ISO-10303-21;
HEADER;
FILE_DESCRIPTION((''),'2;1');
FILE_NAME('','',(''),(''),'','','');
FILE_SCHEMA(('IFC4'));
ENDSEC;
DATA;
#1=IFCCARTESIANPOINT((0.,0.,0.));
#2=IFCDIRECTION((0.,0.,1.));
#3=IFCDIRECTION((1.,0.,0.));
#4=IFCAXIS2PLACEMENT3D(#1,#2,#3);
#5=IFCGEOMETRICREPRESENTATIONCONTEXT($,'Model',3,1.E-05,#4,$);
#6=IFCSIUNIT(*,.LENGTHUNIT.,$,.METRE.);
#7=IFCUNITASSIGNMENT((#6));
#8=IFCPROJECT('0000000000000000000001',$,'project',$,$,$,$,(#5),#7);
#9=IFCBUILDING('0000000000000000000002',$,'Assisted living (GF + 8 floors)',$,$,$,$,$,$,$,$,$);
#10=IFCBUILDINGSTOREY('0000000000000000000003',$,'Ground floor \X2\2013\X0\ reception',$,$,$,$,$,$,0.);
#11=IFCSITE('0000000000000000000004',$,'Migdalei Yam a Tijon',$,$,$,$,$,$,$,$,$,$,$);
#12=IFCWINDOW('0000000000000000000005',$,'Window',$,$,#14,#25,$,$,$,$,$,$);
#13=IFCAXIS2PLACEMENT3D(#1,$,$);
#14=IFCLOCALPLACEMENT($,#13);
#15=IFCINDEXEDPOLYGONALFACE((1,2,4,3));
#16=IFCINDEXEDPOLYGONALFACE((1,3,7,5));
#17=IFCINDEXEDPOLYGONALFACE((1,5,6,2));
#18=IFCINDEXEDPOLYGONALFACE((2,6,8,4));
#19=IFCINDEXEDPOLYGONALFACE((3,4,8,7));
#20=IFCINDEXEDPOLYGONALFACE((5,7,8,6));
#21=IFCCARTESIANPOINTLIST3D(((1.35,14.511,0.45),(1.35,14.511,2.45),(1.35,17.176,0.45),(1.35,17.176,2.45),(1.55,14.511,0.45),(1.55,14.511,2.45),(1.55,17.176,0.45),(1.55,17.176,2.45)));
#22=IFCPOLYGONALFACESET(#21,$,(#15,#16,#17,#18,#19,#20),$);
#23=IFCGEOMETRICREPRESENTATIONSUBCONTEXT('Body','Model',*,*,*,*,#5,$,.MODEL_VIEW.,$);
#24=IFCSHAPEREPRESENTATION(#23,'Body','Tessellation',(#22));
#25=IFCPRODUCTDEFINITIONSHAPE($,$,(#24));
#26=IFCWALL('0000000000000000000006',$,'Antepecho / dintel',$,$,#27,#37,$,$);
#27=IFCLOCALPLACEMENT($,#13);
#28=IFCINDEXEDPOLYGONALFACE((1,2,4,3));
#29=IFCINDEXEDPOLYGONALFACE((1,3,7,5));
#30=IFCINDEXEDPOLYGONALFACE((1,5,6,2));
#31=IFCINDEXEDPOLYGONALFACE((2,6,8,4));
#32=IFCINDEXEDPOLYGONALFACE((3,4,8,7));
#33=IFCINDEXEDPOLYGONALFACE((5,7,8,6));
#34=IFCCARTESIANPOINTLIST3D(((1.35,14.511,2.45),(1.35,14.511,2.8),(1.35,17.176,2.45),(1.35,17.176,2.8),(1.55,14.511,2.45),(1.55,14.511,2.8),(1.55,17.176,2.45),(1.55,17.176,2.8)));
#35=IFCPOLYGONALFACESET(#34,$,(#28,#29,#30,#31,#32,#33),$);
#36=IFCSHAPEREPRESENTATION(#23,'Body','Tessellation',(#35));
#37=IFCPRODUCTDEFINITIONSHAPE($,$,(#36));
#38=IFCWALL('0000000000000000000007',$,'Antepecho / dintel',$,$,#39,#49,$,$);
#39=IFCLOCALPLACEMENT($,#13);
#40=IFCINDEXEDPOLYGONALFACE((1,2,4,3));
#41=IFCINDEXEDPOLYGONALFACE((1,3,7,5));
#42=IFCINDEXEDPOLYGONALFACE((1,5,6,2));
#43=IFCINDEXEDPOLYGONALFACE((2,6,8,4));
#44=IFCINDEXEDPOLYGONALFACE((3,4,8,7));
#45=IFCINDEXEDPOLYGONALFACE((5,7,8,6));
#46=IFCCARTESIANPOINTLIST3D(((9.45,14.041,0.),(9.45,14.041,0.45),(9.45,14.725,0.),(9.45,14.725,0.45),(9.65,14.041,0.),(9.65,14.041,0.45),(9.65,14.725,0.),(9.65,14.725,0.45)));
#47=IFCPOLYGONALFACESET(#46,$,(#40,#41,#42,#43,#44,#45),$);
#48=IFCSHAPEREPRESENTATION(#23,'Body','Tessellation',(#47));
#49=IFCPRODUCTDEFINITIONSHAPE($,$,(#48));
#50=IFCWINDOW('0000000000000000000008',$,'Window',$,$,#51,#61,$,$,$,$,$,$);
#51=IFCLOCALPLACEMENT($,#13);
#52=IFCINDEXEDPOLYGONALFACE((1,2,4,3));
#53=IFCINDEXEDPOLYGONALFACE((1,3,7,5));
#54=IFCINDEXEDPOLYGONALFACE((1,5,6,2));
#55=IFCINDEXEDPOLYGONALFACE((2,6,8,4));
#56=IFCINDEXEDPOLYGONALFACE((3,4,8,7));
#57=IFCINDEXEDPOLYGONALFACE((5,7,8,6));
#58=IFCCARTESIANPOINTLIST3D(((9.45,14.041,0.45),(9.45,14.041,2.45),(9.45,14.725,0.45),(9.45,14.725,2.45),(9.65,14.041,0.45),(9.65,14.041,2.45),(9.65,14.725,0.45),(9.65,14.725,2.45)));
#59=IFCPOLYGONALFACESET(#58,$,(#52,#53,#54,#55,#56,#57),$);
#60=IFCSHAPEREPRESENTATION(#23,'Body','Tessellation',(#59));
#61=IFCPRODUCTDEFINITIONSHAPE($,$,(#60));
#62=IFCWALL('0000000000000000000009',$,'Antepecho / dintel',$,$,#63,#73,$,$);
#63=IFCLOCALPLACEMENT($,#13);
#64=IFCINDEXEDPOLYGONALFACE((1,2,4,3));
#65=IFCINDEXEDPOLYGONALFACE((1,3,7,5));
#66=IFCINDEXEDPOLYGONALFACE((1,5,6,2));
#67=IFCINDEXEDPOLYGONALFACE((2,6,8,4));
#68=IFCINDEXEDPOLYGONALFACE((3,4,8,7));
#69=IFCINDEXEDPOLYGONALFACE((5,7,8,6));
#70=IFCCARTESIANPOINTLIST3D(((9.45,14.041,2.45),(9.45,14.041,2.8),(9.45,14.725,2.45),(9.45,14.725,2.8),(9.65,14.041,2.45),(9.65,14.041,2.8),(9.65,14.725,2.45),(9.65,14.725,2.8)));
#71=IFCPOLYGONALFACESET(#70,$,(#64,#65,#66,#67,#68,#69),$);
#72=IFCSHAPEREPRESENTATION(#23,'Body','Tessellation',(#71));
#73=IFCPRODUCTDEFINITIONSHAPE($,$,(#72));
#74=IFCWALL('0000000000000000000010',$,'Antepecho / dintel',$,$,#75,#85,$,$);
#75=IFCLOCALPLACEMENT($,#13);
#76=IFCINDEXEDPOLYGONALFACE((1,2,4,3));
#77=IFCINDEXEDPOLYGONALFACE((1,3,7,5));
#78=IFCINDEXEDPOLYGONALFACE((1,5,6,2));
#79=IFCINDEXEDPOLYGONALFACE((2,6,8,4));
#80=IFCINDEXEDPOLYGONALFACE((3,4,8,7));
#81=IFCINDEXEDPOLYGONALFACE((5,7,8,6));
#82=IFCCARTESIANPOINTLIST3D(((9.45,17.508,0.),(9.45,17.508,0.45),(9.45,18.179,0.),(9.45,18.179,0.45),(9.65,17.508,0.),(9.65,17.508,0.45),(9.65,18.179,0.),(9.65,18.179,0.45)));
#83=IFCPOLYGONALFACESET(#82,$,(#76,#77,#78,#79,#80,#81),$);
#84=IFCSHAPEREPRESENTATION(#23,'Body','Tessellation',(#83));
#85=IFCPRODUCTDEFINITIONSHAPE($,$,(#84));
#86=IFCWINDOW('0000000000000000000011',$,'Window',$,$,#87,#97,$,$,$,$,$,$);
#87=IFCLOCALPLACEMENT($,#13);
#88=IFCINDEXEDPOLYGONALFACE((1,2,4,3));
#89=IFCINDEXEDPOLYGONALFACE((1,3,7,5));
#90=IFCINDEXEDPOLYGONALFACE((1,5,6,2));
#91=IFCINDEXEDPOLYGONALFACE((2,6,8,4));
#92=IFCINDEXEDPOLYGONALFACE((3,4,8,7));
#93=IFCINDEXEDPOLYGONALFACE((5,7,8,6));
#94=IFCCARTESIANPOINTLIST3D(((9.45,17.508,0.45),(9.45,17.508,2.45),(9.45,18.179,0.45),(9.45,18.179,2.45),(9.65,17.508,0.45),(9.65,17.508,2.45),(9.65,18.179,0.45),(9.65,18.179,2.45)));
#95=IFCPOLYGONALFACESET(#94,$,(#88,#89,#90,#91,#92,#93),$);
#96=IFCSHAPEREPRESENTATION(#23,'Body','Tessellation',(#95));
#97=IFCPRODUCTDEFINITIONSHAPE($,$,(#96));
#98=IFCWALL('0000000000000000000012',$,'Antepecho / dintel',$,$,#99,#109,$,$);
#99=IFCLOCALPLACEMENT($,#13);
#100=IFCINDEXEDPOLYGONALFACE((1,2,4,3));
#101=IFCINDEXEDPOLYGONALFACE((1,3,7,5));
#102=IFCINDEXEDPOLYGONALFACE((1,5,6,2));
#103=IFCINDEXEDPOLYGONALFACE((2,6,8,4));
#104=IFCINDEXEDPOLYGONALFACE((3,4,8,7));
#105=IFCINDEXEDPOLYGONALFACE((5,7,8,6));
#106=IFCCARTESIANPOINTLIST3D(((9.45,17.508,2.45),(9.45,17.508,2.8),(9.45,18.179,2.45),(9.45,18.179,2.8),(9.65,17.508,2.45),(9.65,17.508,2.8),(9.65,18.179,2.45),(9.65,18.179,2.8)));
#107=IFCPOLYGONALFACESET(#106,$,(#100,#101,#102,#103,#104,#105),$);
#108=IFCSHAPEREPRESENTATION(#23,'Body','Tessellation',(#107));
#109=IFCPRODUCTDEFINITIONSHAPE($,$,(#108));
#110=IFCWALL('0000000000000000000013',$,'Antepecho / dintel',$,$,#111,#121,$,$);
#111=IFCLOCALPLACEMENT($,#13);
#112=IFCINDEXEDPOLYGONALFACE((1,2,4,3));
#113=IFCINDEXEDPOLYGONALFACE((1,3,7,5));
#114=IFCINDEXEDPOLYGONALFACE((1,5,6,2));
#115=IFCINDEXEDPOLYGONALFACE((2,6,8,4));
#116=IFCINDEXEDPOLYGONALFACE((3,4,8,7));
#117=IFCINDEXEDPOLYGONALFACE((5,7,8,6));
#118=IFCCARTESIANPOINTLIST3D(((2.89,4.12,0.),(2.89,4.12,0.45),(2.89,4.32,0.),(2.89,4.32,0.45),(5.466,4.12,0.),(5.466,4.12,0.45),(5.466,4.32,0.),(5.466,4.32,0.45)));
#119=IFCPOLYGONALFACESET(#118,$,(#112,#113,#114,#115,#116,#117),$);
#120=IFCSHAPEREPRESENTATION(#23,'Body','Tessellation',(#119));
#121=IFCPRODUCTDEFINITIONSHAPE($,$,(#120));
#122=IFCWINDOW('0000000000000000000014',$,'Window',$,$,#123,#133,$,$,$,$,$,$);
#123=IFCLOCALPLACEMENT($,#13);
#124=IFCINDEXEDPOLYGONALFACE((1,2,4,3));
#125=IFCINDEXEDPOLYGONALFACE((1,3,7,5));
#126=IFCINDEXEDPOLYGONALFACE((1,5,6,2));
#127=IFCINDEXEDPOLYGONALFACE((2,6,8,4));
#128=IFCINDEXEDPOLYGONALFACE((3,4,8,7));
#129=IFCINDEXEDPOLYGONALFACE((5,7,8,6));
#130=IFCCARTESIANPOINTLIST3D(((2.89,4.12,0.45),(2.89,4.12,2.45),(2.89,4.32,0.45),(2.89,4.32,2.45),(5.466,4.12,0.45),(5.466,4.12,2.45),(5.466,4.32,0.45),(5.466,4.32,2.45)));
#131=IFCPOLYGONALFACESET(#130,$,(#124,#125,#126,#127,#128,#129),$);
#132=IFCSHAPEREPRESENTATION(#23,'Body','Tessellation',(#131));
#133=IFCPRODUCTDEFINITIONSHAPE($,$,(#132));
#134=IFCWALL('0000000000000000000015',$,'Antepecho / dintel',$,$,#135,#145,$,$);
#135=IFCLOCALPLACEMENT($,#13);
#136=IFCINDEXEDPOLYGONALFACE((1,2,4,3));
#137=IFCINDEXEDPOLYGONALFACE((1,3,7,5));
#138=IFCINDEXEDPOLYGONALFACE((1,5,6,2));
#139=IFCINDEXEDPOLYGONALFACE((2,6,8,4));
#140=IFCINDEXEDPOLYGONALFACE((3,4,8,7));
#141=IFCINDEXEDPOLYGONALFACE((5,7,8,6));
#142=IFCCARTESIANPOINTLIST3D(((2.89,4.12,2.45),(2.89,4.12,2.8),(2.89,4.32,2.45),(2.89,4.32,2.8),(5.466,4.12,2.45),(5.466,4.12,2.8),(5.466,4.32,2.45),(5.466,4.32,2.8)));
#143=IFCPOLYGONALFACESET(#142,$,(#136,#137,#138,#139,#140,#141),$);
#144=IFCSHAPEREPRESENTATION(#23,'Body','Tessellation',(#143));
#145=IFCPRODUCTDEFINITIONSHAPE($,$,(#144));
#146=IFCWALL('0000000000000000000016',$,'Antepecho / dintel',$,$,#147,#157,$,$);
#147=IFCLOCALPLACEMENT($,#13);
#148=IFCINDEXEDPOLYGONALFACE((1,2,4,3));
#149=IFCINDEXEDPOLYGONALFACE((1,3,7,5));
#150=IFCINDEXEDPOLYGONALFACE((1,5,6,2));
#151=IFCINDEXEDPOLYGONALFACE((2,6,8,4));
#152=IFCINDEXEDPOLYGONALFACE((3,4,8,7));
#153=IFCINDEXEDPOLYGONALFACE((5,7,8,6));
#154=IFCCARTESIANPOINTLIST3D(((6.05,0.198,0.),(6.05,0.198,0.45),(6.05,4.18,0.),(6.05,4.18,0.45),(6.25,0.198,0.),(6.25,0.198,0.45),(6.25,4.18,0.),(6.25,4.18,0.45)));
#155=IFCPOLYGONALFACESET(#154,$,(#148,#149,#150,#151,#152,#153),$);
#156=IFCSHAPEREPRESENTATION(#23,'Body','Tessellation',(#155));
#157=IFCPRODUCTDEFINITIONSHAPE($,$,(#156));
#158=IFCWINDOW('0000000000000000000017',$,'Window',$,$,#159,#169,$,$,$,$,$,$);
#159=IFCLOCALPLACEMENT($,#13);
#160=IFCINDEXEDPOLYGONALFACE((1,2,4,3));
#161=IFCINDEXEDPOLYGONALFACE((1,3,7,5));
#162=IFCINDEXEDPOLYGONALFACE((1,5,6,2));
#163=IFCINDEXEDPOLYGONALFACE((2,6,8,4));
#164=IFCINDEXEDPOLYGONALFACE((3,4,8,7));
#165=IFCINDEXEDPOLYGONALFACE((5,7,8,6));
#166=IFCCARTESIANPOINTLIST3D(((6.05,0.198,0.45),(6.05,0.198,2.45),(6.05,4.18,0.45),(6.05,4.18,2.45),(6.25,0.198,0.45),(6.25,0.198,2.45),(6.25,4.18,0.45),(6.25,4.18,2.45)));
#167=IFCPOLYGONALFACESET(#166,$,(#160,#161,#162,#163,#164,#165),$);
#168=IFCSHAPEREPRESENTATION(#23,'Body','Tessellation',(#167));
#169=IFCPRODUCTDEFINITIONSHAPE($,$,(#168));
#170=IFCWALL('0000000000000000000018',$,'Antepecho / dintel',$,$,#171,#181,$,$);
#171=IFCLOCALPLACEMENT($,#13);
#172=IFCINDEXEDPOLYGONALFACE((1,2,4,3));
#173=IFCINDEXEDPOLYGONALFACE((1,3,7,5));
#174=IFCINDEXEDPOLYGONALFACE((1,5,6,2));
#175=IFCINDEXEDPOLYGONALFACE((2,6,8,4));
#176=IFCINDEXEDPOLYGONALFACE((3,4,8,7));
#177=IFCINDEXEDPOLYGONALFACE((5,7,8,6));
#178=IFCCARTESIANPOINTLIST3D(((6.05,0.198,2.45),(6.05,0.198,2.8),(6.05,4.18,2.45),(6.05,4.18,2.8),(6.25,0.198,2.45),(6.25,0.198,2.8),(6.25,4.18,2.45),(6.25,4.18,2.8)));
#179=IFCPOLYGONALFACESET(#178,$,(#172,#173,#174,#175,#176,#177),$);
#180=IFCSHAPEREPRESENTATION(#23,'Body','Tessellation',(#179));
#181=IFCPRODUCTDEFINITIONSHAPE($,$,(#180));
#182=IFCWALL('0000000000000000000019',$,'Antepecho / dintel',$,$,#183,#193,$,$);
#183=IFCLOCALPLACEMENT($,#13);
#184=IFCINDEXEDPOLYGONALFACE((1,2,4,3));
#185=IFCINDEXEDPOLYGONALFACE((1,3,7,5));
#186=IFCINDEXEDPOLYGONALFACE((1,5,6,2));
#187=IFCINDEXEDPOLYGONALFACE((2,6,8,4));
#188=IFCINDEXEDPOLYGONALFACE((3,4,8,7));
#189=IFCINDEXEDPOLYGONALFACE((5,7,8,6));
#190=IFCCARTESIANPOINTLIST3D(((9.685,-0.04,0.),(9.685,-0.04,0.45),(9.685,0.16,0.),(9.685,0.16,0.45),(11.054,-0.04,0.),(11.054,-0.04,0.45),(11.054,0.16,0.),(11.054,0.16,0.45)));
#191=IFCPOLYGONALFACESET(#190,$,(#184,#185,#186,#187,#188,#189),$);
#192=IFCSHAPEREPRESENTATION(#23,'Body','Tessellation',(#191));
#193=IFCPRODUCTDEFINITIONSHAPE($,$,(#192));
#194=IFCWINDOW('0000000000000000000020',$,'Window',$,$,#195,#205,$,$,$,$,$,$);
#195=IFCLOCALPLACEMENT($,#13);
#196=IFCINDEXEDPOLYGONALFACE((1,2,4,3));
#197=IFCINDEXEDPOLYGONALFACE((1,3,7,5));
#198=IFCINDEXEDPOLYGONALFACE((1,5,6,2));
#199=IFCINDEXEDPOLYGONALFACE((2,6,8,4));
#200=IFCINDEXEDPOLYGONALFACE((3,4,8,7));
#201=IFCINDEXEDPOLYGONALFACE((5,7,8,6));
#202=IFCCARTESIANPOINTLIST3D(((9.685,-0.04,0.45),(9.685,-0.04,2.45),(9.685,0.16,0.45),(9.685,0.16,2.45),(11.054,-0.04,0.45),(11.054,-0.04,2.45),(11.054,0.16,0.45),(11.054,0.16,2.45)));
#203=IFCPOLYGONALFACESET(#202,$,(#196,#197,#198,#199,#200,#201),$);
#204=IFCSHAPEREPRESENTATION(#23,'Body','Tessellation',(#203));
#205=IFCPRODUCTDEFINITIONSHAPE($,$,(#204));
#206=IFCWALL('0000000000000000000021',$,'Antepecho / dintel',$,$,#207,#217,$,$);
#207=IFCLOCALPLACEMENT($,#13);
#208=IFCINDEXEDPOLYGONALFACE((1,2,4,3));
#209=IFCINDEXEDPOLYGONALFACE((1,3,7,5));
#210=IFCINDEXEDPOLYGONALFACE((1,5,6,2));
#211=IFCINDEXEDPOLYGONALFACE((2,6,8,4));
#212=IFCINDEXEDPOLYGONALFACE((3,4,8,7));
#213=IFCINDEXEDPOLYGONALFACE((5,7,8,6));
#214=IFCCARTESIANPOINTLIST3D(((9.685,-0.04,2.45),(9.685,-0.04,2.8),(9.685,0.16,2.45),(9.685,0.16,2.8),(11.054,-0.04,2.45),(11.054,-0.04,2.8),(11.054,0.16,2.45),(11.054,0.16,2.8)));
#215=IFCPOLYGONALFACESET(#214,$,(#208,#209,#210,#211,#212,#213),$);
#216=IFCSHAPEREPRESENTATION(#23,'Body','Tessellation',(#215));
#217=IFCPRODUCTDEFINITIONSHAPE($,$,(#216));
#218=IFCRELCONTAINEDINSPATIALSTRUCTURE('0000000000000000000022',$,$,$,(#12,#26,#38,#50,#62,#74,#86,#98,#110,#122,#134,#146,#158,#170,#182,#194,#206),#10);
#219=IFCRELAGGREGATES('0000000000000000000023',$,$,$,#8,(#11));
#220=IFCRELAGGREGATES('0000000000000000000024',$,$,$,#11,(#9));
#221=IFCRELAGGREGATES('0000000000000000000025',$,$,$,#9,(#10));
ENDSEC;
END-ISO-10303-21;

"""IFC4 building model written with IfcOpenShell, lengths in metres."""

from ifc_helpers import new_model, si_unit, frame, origin_with_axes, context, subcontext, project, spatial, line, indexed_curve, outline, extrude, element, save


model = new_model("IFC4")

# Units and contexts
model_context = context("Model", 3, precision=1e-05, world=origin_with_axes())
body_context = subcontext(model_context, "Body", "Model", "MODEL_VIEW")
ifc_project = project(units=[si_unit("LENGTHUNIT", "METRE")], contexts=[model_context])

# Site, building, storey
site = spatial("IfcSite", under=ifc_project, Name="Migdalei Yam a Tijon")
building = spatial("IfcBuilding", under=site, Name="Assisted living (GF + 8 floors)")
storey = spatial("IfcBuildingStorey", under=building, Name="Ground floor – reception", Elevation=0.0)

# Window
element("IfcWindow", 1, inside=storey, Name="Window", context=body_context, shape_type="SweptSolid", body=[
    extrude(outline(indexed_curve([(0.0, 0.0), (0.2, 0.0), (0.2, 2.665), (0.0, 2.665)], segments=[line(1, 2, 3, 4, 1)])), frame((1.35, 14.511, 0.45), z_axis=(0.0, 0.0, 1.0), x_axis=(1.0, 0.0, 0.0)), (0.0, 0.0, 1.0), 2.0),
])

# Walls
element("IfcWall", 2, inside=storey, Name="Antepecho / dintel", context=body_context, shape_type="SweptSolid", body=[
    extrude(outline(indexed_curve([(0.0, 0.0), (0.2, 0.0), (0.2, 2.665), (0.0, 2.665)], segments=[line(1, 2, 3, 4, 1)])), frame((1.35, 14.511, 2.45), z_axis=(0.0, 0.0, 1.0), x_axis=(1.0, 0.0, 0.0)), (0.0, 0.0, 1.0), 0.35),
])
element("IfcWall", 3, inside=storey, Name="Antepecho / dintel", context=body_context, shape_type="SweptSolid", body=[
    extrude(outline(indexed_curve([(0.0, 0.0), (0.2, 0.0), (0.2, 0.684), (0.0, 0.684)], segments=[line(1, 2, 3, 4, 1)])), frame((9.45, 14.041, 0.0), z_axis=(0.0, 0.0, 1.0), x_axis=(1.0, 0.0, 0.0)), (0.0, 0.0, 1.0), 0.45),
])

# Window
element("IfcWindow", 4, inside=storey, Name="Window", context=body_context, shape_type="SweptSolid", body=[
    extrude(outline(indexed_curve([(0.0, 0.0), (0.2, 0.0), (0.2, 0.684), (0.0, 0.684)], segments=[line(1, 2, 3, 4, 1)])), frame((9.45, 14.041, 0.45), z_axis=(0.0, 0.0, 1.0), x_axis=(1.0, 0.0, 0.0)), (0.0, 0.0, 1.0), 2.0),
])

# Walls
element("IfcWall", 5, inside=storey, Name="Antepecho / dintel", context=body_context, shape_type="SweptSolid", body=[
    extrude(outline(indexed_curve([(0.0, 0.0), (0.2, 0.0), (0.2, 0.684), (0.0, 0.684)], segments=[line(1, 2, 3, 4, 1)])), frame((9.45, 14.041, 2.45), z_axis=(0.0, 0.0, 1.0), x_axis=(1.0, 0.0, 0.0)), (0.0, 0.0, 1.0), 0.35),
])
element("IfcWall", 6, inside=storey, Name="Antepecho / dintel", context=body_context, shape_type="SweptSolid", body=[
    extrude(outline(indexed_curve([(0.0, 0.0), (0.2, 0.0), (0.2, 0.671), (0.0, 0.671)], segments=[line(1, 2, 3, 4, 1)])), frame((9.45, 17.508, 0.0), z_axis=(0.0, 0.0, 1.0), x_axis=(1.0, 0.0, 0.0)), (0.0, 0.0, 1.0), 0.45),
])

# Window
element("IfcWindow", 7, inside=storey, Name="Window", context=body_context, shape_type="SweptSolid", body=[
    extrude(outline(indexed_curve([(0.0, 0.0), (0.2, 0.0), (0.2, 0.671), (0.0, 0.671)], segments=[line(1, 2, 3, 4, 1)])), frame((9.45, 17.508, 0.45), z_axis=(0.0, 0.0, 1.0), x_axis=(1.0, 0.0, 0.0)), (0.0, 0.0, 1.0), 2.0),
])

# Walls
element("IfcWall", 8, inside=storey, Name="Antepecho / dintel", context=body_context, shape_type="SweptSolid", body=[
    extrude(outline(indexed_curve([(0.0, 0.0), (0.2, 0.0), (0.2, 0.671), (0.0, 0.671)], segments=[line(1, 2, 3, 4, 1)])), frame((9.45, 17.508, 2.45), z_axis=(0.0, 0.0, 1.0), x_axis=(1.0, 0.0, 0.0)), (0.0, 0.0, 1.0), 0.35),
])
element("IfcWall", 9, inside=storey, Name="Antepecho / dintel", context=body_context, shape_type="SweptSolid", body=[
    extrude(outline(indexed_curve([(0.0, 0.0), (2.576, 0.0), (2.576, 0.2), (0.0, 0.2)], segments=[line(1, 2, 3, 4, 1)])), frame((2.89, 4.12, 0.0), z_axis=(0.0, 0.0, 1.0), x_axis=(1.0, 0.0, 0.0)), (0.0, 0.0, 1.0), 0.45),
])

# Window
element("IfcWindow", 10, inside=storey, Name="Window", context=body_context, shape_type="SweptSolid", body=[
    extrude(outline(indexed_curve([(0.0, 0.0), (2.576, 0.0), (2.576, 0.2), (0.0, 0.2)], segments=[line(1, 2, 3, 4, 1)])), frame((2.89, 4.12, 0.45), z_axis=(0.0, 0.0, 1.0), x_axis=(1.0, 0.0, 0.0)), (0.0, 0.0, 1.0), 2.0),
])

# Walls
element("IfcWall", 11, inside=storey, Name="Antepecho / dintel", context=body_context, shape_type="SweptSolid", body=[
    extrude(outline(indexed_curve([(0.0, 0.0), (2.576, 0.0), (2.576, 0.2), (0.0, 0.2)], segments=[line(1, 2, 3, 4, 1)])), frame((2.89, 4.12, 2.45), z_axis=(0.0, 0.0, 1.0), x_axis=(1.0, 0.0, 0.0)), (0.0, 0.0, 1.0), 0.35),
])
element("IfcWall", 12, inside=storey, Name="Antepecho / dintel", context=body_context, shape_type="SweptSolid", body=[
    extrude(outline(indexed_curve([(0.0, 0.0), (0.2, 0.0), (0.2, 3.982), (0.0, 3.982)], segments=[line(1, 2, 3, 4, 1)])), frame((6.05, 0.198, 0.0), z_axis=(0.0, 0.0, 1.0), x_axis=(1.0, 0.0, 0.0)), (0.0, 0.0, 1.0), 0.45),
])

# Window
element("IfcWindow", 13, inside=storey, Name="Window", context=body_context, shape_type="SweptSolid", body=[
    extrude(outline(indexed_curve([(0.0, 0.0), (0.2, 0.0), (0.2, 3.982), (0.0, 3.982)], segments=[line(1, 2, 3, 4, 1)])), frame((6.05, 0.198, 0.45), z_axis=(0.0, 0.0, 1.0), x_axis=(1.0, 0.0, 0.0)), (0.0, 0.0, 1.0), 2.0),
])

# Walls
element("IfcWall", 14, inside=storey, Name="Antepecho / dintel", context=body_context, shape_type="SweptSolid", body=[
    extrude(outline(indexed_curve([(0.0, 0.0), (0.2, 0.0), (0.2, 3.982), (0.0, 3.982)], segments=[line(1, 2, 3, 4, 1)])), frame((6.05, 0.198, 2.45), z_axis=(0.0, 0.0, 1.0), x_axis=(1.0, 0.0, 0.0)), (0.0, 0.0, 1.0), 0.35),
])
element("IfcWall", 15, inside=storey, Name="Antepecho / dintel", context=body_context, shape_type="SweptSolid", body=[
    extrude(outline(indexed_curve([(0.0, 0.0), (1.369, 0.0), (1.369, 0.2), (0.0, 0.2)], segments=[line(1, 2, 3, 4, 1)])), frame((9.685, -0.04, 0.0), z_axis=(0.0, 0.0, 1.0), x_axis=(1.0, 0.0, 0.0)), (0.0, 0.0, 1.0), 0.45),
])

# Window
element("IfcWindow", 16, inside=storey, Name="Window", context=body_context, shape_type="SweptSolid", body=[
    extrude(outline(indexed_curve([(0.0, 0.0), (1.369, 0.0), (1.369, 0.2), (0.0, 0.2)], segments=[line(1, 2, 3, 4, 1)])), frame((9.685, -0.04, 0.45), z_axis=(0.0, 0.0, 1.0), x_axis=(1.0, 0.0, 0.0)), (0.0, 0.0, 1.0), 2.0),
])

# Wall
element("IfcWall", 17, inside=storey, Name="Antepecho / dintel", context=body_context, shape_type="SweptSolid", body=[
    extrude(outline(indexed_curve([(0.0, 0.0), (1.369, 0.0), (1.369, 0.2), (0.0, 0.2)], segments=[line(1, 2, 3, 4, 1)])), frame((9.685, -0.04, 2.45), z_axis=(0.0, 0.0, 1.0), x_axis=(1.0, 0.0, 0.0)), (0.0, 0.0, 1.0), 0.35),
])

save(model, "model.ifc")
